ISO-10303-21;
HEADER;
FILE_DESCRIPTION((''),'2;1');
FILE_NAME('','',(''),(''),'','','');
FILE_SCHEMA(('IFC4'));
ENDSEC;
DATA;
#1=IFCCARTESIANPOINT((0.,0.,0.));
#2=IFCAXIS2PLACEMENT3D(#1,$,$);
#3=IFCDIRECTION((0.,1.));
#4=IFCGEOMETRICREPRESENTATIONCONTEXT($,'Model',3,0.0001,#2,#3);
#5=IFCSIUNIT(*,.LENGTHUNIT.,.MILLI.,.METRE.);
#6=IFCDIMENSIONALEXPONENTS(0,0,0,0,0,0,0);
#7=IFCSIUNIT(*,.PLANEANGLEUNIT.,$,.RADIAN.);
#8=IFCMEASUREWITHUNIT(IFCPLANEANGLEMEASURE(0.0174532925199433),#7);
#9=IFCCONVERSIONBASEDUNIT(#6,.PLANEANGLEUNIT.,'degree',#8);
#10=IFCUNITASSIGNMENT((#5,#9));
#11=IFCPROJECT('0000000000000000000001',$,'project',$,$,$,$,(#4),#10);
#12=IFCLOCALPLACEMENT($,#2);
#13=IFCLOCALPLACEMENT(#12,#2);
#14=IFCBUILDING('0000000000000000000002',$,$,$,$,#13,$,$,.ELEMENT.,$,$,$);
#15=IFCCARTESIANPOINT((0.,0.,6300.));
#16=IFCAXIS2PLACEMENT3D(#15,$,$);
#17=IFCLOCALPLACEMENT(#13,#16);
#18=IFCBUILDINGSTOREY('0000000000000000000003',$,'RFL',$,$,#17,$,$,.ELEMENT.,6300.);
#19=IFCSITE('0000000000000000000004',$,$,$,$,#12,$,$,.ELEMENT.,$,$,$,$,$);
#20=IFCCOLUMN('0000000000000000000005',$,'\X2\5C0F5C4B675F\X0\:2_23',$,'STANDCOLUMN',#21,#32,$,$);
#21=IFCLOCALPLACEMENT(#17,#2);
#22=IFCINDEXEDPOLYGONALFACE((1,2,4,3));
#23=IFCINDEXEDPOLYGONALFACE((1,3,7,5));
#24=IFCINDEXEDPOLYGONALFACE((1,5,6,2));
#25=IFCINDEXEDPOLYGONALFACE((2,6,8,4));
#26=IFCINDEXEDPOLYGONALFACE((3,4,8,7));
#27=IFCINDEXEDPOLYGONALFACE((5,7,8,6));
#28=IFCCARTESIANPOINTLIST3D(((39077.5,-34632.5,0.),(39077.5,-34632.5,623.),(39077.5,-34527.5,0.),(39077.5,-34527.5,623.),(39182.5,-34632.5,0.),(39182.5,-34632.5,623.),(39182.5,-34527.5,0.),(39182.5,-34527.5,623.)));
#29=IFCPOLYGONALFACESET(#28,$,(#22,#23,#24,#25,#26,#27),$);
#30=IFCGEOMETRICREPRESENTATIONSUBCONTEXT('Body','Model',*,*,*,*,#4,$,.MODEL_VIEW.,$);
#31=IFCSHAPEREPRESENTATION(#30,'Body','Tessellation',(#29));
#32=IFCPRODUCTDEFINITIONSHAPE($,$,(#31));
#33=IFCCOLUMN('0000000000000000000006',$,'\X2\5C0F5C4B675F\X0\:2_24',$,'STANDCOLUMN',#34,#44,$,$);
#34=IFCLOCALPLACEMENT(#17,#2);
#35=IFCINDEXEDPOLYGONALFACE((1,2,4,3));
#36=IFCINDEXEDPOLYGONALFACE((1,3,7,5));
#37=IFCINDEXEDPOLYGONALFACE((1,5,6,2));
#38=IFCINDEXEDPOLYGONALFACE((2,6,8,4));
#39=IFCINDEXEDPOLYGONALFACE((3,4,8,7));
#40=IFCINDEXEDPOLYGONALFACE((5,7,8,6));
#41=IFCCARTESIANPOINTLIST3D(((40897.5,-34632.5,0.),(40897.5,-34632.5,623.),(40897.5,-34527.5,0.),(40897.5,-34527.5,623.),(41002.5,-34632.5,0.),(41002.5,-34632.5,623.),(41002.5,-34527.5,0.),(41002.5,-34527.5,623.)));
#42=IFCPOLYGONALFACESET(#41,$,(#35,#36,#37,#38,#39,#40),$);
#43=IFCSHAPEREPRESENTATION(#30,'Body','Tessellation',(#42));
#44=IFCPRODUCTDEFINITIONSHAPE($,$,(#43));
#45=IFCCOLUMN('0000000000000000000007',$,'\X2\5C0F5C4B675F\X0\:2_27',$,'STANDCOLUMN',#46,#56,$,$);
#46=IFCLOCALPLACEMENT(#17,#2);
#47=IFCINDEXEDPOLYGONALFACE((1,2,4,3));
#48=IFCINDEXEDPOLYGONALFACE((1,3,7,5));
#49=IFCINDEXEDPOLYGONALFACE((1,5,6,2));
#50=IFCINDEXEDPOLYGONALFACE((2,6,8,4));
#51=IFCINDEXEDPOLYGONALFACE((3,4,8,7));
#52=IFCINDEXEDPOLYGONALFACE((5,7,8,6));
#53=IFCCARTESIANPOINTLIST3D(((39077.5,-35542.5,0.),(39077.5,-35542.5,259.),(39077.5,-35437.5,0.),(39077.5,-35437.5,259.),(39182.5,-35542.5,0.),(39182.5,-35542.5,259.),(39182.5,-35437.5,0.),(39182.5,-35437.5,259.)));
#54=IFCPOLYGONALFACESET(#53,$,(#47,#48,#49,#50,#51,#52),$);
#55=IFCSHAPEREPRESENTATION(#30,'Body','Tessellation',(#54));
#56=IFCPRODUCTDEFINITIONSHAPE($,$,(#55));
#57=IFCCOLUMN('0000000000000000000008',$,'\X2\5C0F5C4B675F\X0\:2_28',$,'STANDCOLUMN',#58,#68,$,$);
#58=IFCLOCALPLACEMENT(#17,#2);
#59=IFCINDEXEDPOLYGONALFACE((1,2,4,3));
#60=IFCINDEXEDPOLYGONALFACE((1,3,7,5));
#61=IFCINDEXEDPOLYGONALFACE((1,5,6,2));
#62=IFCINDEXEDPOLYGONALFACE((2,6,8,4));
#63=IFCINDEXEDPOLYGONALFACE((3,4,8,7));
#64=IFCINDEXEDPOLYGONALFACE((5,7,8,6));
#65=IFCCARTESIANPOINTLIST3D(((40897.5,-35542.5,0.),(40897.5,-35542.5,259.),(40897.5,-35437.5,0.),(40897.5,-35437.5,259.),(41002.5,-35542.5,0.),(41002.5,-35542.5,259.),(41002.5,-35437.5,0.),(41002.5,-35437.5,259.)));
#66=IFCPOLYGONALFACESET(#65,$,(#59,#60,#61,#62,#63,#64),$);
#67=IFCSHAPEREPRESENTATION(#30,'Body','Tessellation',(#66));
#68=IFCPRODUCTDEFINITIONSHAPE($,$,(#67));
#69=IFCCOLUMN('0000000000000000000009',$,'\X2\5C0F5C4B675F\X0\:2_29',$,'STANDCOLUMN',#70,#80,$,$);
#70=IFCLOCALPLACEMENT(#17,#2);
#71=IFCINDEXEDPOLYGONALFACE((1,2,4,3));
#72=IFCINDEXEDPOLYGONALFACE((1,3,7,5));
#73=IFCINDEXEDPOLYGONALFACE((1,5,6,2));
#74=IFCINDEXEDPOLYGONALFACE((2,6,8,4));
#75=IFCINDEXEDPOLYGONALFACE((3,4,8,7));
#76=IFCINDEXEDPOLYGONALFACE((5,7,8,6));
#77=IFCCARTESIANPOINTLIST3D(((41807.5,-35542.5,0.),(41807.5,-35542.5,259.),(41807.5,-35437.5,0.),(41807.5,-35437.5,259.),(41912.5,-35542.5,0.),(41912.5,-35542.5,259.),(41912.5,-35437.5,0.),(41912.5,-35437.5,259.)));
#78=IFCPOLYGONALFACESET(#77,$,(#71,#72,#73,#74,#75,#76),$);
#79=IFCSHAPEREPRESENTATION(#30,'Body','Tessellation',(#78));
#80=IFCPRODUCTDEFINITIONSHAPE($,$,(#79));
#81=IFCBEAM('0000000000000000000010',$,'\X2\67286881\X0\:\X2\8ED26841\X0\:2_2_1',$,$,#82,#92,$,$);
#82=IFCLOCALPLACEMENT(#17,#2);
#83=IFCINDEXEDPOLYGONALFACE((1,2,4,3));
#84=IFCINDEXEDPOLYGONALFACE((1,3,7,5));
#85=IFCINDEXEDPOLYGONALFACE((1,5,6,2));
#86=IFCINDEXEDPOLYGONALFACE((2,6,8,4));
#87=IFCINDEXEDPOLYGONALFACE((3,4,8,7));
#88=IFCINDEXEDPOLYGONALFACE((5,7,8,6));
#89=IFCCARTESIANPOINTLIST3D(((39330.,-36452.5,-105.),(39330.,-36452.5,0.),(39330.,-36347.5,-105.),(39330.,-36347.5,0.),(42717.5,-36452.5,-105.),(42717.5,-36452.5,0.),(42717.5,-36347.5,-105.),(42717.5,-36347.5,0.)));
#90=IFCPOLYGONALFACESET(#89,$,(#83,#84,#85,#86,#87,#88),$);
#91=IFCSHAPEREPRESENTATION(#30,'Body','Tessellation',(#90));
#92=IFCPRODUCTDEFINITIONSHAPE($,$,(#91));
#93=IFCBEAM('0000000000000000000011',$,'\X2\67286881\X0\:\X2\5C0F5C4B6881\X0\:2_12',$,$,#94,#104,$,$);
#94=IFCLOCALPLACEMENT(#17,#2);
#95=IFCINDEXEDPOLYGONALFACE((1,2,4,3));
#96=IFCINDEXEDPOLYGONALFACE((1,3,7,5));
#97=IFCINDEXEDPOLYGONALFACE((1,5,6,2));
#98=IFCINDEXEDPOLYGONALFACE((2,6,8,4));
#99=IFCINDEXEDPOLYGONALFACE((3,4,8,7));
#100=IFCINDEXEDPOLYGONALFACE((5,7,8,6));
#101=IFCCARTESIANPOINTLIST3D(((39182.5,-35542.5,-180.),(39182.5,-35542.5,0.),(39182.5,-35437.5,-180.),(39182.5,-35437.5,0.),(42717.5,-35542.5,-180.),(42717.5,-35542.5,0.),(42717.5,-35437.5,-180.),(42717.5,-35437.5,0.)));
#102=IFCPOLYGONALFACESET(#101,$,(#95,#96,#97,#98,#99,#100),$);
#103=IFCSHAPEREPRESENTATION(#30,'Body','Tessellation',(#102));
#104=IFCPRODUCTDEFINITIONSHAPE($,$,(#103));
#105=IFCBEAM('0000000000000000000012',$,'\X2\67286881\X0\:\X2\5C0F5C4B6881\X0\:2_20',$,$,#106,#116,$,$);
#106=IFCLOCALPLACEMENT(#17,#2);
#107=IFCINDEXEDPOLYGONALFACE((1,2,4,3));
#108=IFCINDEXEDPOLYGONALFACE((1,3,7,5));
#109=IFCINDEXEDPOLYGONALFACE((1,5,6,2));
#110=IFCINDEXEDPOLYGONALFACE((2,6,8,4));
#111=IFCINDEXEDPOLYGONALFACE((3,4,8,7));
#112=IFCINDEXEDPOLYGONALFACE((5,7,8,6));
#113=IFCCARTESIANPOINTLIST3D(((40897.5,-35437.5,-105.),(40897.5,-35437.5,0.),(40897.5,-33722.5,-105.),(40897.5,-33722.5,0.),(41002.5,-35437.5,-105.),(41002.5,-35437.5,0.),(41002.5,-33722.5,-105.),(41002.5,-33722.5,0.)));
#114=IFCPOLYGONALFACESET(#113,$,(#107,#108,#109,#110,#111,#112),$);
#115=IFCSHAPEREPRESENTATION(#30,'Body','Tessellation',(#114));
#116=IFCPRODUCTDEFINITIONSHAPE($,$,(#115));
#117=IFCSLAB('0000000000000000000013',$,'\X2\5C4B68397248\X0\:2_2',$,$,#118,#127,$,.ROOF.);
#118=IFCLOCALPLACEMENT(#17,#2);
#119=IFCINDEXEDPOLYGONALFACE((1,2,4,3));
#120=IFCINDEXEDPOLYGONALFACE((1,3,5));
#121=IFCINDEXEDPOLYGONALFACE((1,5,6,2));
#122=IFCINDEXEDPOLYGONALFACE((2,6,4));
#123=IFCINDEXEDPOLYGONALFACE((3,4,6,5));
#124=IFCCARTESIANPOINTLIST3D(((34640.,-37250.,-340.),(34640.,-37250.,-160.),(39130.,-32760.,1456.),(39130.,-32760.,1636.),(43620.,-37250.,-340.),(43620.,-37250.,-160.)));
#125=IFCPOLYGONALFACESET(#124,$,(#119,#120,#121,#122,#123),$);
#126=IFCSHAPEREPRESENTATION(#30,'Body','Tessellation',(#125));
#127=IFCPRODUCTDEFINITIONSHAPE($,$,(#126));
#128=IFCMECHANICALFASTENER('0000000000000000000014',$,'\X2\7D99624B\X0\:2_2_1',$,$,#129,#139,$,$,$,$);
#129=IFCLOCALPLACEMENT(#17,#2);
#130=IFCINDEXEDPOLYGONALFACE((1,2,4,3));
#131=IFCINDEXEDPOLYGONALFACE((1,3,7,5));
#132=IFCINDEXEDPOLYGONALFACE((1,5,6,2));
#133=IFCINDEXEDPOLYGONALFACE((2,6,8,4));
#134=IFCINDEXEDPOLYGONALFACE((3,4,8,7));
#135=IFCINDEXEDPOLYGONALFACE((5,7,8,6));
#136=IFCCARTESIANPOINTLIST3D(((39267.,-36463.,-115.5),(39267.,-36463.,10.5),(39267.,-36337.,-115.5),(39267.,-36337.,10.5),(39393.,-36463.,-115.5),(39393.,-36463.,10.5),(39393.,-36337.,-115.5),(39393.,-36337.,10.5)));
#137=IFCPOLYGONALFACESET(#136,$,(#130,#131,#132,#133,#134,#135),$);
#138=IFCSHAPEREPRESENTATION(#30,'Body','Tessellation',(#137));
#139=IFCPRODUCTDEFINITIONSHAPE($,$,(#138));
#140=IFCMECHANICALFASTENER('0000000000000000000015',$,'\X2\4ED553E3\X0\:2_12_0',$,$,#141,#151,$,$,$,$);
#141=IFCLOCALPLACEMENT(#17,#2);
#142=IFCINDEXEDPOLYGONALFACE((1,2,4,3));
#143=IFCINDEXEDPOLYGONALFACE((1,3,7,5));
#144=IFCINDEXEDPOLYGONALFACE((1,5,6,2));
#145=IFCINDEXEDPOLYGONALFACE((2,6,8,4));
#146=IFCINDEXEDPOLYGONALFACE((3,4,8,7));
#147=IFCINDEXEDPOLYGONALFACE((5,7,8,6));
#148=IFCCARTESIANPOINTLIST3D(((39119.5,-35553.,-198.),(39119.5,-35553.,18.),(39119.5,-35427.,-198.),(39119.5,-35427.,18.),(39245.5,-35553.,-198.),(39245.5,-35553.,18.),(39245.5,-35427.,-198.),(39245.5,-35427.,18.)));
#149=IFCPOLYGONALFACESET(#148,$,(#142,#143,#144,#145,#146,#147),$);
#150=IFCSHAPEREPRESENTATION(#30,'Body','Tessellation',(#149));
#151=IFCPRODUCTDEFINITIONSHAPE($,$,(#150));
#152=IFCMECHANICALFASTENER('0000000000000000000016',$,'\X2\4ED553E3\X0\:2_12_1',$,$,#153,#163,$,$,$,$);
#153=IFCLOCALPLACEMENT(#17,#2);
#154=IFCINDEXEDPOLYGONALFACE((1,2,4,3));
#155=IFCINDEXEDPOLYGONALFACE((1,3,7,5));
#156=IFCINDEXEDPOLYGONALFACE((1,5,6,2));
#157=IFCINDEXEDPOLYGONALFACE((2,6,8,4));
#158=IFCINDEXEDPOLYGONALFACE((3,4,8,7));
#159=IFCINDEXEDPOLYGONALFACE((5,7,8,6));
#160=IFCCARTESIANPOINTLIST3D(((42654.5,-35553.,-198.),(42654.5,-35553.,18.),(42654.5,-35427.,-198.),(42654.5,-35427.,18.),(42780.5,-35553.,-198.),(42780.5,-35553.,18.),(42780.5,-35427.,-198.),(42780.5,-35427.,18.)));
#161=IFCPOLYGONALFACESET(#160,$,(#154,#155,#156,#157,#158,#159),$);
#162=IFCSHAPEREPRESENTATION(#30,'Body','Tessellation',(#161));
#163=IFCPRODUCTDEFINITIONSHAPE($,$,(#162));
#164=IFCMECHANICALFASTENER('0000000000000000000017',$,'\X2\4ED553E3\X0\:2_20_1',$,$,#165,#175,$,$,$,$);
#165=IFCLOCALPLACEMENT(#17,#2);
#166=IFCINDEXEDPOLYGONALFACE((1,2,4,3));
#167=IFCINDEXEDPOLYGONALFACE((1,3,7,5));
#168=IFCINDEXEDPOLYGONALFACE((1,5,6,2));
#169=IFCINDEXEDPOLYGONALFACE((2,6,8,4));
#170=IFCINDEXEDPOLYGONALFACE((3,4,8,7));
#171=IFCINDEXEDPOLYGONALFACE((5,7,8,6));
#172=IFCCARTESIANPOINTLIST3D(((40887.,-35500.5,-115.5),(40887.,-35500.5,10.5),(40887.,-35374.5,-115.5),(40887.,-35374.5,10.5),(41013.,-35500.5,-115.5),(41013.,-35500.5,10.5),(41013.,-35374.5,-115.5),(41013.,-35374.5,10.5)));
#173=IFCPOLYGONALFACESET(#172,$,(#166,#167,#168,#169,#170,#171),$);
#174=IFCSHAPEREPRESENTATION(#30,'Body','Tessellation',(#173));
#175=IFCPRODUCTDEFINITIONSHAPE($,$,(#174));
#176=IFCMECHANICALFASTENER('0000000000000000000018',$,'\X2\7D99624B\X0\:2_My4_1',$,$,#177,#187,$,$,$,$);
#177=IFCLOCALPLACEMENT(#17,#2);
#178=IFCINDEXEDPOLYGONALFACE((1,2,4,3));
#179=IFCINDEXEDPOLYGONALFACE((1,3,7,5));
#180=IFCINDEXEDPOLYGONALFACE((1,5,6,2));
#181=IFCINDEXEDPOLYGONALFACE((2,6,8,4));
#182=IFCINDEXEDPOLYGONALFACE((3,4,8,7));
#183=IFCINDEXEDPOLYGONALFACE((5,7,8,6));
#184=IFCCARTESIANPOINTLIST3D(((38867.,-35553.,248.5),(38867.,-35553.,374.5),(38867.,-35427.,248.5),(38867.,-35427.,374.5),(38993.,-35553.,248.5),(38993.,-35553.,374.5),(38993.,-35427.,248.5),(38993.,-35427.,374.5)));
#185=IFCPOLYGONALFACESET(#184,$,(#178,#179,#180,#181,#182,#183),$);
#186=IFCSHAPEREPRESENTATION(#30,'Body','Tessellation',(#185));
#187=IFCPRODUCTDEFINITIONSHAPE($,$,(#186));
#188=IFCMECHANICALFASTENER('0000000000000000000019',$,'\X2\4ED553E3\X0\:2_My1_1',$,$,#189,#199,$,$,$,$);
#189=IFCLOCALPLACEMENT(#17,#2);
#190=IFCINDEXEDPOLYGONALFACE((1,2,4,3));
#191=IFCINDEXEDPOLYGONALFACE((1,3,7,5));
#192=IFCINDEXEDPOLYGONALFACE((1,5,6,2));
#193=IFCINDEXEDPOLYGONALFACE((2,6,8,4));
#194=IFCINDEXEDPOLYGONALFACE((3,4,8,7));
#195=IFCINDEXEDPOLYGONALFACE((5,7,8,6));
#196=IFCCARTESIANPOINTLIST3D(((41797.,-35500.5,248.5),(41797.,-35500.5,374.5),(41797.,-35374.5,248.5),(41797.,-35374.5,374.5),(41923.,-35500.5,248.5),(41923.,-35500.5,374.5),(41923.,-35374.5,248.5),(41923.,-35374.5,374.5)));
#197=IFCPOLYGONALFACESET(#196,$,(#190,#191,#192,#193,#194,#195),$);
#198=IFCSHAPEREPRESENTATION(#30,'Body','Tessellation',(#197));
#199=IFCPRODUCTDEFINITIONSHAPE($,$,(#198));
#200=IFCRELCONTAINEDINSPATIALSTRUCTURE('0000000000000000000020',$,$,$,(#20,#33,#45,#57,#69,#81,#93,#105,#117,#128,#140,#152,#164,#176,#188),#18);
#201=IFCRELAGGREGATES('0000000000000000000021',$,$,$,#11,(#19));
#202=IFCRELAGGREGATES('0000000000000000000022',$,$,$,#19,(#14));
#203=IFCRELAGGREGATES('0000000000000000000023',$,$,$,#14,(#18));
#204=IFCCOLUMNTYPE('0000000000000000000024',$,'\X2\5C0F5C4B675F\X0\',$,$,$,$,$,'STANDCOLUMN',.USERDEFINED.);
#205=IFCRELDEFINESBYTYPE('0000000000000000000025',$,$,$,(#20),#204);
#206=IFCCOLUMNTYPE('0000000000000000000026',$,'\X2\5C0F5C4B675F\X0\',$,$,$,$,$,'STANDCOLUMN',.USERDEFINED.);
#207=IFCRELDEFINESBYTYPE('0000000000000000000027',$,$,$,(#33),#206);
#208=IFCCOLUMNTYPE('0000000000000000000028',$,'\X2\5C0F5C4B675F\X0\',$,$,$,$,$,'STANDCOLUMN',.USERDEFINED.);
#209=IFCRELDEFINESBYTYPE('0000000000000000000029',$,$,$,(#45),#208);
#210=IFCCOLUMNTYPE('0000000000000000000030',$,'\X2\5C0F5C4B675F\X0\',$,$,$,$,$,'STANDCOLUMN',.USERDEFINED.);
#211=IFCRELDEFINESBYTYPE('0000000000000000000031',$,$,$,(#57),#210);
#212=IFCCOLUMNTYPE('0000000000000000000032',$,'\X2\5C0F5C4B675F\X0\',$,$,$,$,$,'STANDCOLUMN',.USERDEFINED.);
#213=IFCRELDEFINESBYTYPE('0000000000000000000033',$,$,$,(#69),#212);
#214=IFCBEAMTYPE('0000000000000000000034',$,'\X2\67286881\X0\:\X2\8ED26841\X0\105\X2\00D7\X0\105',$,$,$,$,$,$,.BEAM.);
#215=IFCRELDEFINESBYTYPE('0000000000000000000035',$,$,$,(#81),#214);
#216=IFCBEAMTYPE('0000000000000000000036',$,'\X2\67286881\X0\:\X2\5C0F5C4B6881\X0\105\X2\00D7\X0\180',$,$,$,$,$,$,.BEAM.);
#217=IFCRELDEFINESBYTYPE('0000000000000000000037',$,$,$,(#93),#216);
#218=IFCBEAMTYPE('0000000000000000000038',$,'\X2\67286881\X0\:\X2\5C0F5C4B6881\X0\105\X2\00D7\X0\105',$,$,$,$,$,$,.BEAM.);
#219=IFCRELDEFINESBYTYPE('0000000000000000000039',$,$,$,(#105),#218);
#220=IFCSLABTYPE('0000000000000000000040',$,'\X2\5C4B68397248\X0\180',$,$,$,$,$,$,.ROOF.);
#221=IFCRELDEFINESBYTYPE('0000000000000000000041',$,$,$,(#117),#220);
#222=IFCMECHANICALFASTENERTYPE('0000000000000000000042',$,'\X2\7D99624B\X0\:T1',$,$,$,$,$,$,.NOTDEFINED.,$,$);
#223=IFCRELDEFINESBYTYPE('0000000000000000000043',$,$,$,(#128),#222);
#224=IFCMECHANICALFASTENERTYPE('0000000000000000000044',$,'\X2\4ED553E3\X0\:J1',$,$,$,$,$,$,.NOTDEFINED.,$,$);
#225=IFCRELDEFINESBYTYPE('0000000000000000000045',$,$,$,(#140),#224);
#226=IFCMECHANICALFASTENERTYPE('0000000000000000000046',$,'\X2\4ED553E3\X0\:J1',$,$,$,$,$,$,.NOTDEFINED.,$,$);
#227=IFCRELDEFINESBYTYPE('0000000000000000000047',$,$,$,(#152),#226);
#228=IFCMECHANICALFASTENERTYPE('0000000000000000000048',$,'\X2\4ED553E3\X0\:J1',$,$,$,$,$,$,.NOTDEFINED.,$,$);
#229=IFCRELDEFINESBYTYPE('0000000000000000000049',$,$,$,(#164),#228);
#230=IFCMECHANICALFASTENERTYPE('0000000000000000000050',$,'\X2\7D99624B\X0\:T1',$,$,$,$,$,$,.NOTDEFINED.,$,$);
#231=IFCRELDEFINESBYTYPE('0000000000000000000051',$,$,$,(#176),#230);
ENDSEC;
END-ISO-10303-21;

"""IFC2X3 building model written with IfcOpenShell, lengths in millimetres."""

from ifc_helpers import new_model, entity, si_unit, converted_unit, direction, frame, origin, origin_with_axes, origin_2d, place, context, subcontext, project, spatial, polyline, rectangle, outline, extrude, type_object, element, save


model = new_model("IFC2X3")

# Units and contexts
model_context = context("Model", 3, precision=0.0001, world=origin(), true_north=direction((0.0, 1.0)))
body_context = subcontext(model_context, "Body", "Model", "MODEL_VIEW")
ifc_project = project(units=[si_unit("LENGTHUNIT", "METRE", prefix="MILLI"), converted_unit("PLANEANGLEUNIT", "degree", entity("IfcPlaneAngleMeasure", 0.0174532925199433), si_unit("PLANEANGLEUNIT", "RADIAN"), dimensions=[0, 0, 0, 0, 0, 0, 0])], contexts=[model_context])

# Site, building, storey
site_placement = place(None, origin())
site = spatial("IfcSite", under=ifc_project, at=site_placement, CompositionType="ELEMENT")
building_placement = place(site_placement, origin())
building = spatial("IfcBuilding", under=site, at=building_placement, CompositionType="ELEMENT")
storey_placement = place(building_placement, frame((0.0, 0.0, 6300.0)))
storey = spatial("IfcBuildingStorey", under=building, at=storey_placement, Name="RFL", CompositionType="ELEMENT", Elevation=6300.0)

# Columns
column_type_1 = type_object("IfcColumnType", Name="小屋束", ElementType="STANDCOLUMN", PredefinedType="USERDEFINED")
column_1_placement = place(storey_placement, frame((39130.0, -34580.0, 0.0)))
element("IfcColumn", 1, at=column_1_placement, inside=storey, type_object=column_type_1, Name="小屋束:2_23", ObjectType="STANDCOLUMN", context=body_context, shape_type="SweptSolid", body=[
    extrude(rectangle(XDim=105.0, YDim=105.0, at=origin_2d()), origin_with_axes(), (0.0, 0.0, 1.0), 623.0),
])
column_type_2 = type_object("IfcColumnType", Name="小屋束", ElementType="STANDCOLUMN", PredefinedType="USERDEFINED")
column_2_placement = place(storey_placement, frame((40950.0, -34580.0, 0.0)))
element("IfcColumn", 2, at=column_2_placement, inside=storey, type_object=column_type_2, Name="小屋束:2_24", ObjectType="STANDCOLUMN", context=body_context, shape_type="SweptSolid", body=[
    extrude(rectangle(XDim=105.0, YDim=105.0, at=origin_2d()), origin_with_axes(), (0.0, 0.0, 1.0), 623.0),
])
column_type_3 = type_object("IfcColumnType", Name="小屋束", ElementType="STANDCOLUMN", PredefinedType="USERDEFINED")
column_3_placement = place(storey_placement, frame((39130.0, -35490.0, 0.0)))
element("IfcColumn", 3, at=column_3_placement, inside=storey, type_object=column_type_3, Name="小屋束:2_27", ObjectType="STANDCOLUMN", context=body_context, shape_type="SweptSolid", body=[
    extrude(rectangle(XDim=105.0, YDim=105.0, at=origin_2d()), origin_with_axes(), (0.0, 0.0, 1.0), 259.0),
])
column_type_4 = type_object("IfcColumnType", Name="小屋束", ElementType="STANDCOLUMN", PredefinedType="USERDEFINED")
column_4_placement = place(storey_placement, frame((40950.0, -35490.0, 0.0)))
element("IfcColumn", 4, at=column_4_placement, inside=storey, type_object=column_type_4, Name="小屋束:2_28", ObjectType="STANDCOLUMN", context=body_context, shape_type="SweptSolid", body=[
    extrude(rectangle(XDim=105.0, YDim=105.0, at=origin_2d()), origin_with_axes(), (0.0, 0.0, 1.0), 259.0),
])
column_type_5 = type_object("IfcColumnType", Name="小屋束", ElementType="STANDCOLUMN", PredefinedType="USERDEFINED")
column_5_placement = place(storey_placement, frame((41860.0, -35490.0, 0.0)))
element("IfcColumn", 5, at=column_5_placement, inside=storey, type_object=column_type_5, Name="小屋束:2_29", ObjectType="STANDCOLUMN", context=body_context, shape_type="SweptSolid", body=[
    extrude(rectangle(XDim=105.0, YDim=105.0, at=origin_2d()), origin_with_axes(), (0.0, 0.0, 1.0), 259.0),
])

# Beams
beam_type_1 = type_object("IfcBeamType", Name="木梁:軒桁105×105", PredefinedType="BEAM")
beam_1_placement = place(storey_placement, frame((39330.0, -36400.0, -52.5), z_axis=(1.0, 0.0, 0.0), x_axis=(0.0, 1.0, 0.0)))
element("IfcBeam", 6, at=beam_1_placement, inside=storey, type_object=beam_type_1, Name="木梁:軒桁:2_2_1", context=body_context, shape_type="SweptSolid", body=[
    extrude(rectangle(XDim=105.0, YDim=105.0, at=origin_2d()), origin_with_axes(), (0.0, 0.0, 1.0), 3387.5),
])
beam_type_2 = type_object("IfcBeamType", Name="木梁:小屋梁105×180", PredefinedType="BEAM")
beam_2_placement = place(storey_placement, frame((39182.5, -35490.0, -90.0), z_axis=(1.0, 0.0, 0.0), x_axis=(0.0, 1.0, 0.0)))
element("IfcBeam", 7, at=beam_2_placement, inside=storey, type_object=beam_type_2, Name="木梁:小屋梁:2_12", context=body_context, shape_type="SweptSolid", body=[
    extrude(rectangle(XDim=105.0, YDim=180.0, at=origin_2d()), origin_with_axes(), (0.0, 0.0, 1.0), 3535.0),
])
beam_type_3 = type_object("IfcBeamType", Name="木梁:小屋梁105×105", PredefinedType="BEAM")
beam_3_placement = place(storey_placement, frame((40950.0, -33722.5, -52.5), z_axis=(0.0, -1.0, 0.0), x_axis=(1.0, 0.0, 0.0)))
element("IfcBeam", 8, at=beam_3_placement, inside=storey, type_object=beam_type_3, Name="木梁:小屋梁:2_20", context=body_context, shape_type="SweptSolid", body=[
    extrude(rectangle(XDim=105.0, YDim=105.0, at=origin_2d()), origin_with_axes(), (0.0, 0.0, 1.0), 1715.0),
])

# Slab
slab_type = type_object("IfcSlabType", Name="屋根版180", PredefinedType="ROOF")
slab_placement = place(storey_placement, frame((43620.0, -37250.0, -340.0), z_axis=(0.0, 0.371391, -0.928477), x_axis=(-1.0, 0.0, 0.0)))
element("IfcSlab", 9, at=slab_placement, inside=storey, type_object=slab_type, Name="屋根版:2_2", PredefinedType="ROOF", context=body_context, shape_type="SweptSolid", body=[
    extrude(outline(polyline([(0.0, 0.0, 0.0), (8980.0, 0.0, 0.0), (4490.0, 4835.9, 0.0), (0.0, 0.0, 0.0)])), origin_with_axes(), (0.0, 0.371391, -0.928477), 180.0),
])

# Mechanical fasteners
mechanical_fastener_type_1 = type_object("IfcMechanicalFastenerType", Name="継手:T1")
mechanical_fastener_1_placement = place(storey_placement, frame((39330.0, -36400.0, -115.5)))
element("IfcMechanicalFastener", 10, at=mechanical_fastener_1_placement, inside=storey, type_object=mechanical_fastener_type_1, Name="継手:2_2_1", context=body_context, shape_type="SweptSolid", body=[
    extrude(rectangle(XDim=126.0, YDim=126.0, at=origin_2d()), origin_with_axes(), (0.0, 0.0, 1.0), 126.0),
])
mechanical_fastener_type_2 = type_object("IfcMechanicalFastenerType", Name="仕口:J1")
mechanical_fastener_2_placement = place(storey_placement, frame((39182.5, -35490.0, -198.0)))
element("IfcMechanicalFastener", 11, at=mechanical_fastener_2_placement, inside=storey, type_object=mechanical_fastener_type_2, Name="仕口:2_12_0", context=body_context, shape_type="SweptSolid", body=[
    extrude(rectangle(XDim=126.0, YDim=126.0, at=origin_2d()), origin_with_axes(), (0.0, 0.0, 1.0), 216.0),
])
mechanical_fastener_type_3 = type_object("IfcMechanicalFastenerType", Name="仕口:J1")
mechanical_fastener_3_placement = place(storey_placement, frame((42717.5, -35490.0, -198.0)))
element("IfcMechanicalFastener", 12, at=mechanical_fastener_3_placement, inside=storey, type_object=mechanical_fastener_type_3, Name="仕口:2_12_1", context=body_context, shape_type="SweptSolid", body=[
    extrude(rectangle(XDim=126.0, YDim=126.0, at=origin_2d()), origin_with_axes(), (0.0, 0.0, 1.0), 216.0),
])
mechanical_fastener_type_4 = type_object("IfcMechanicalFastenerType", Name="仕口:J1")
mechanical_fastener_4_placement = place(storey_placement, frame((40950.0, -35437.5, -115.5)))
element("IfcMechanicalFastener", 13, at=mechanical_fastener_4_placement, inside=storey, type_object=mechanical_fastener_type_4, Name="仕口:2_20_1", context=body_context, shape_type="SweptSolid", body=[
    extrude(rectangle(XDim=126.0, YDim=126.0, at=origin_2d()), origin_with_axes(), (0.0, 0.0, 1.0), 126.0),
])
mechanical_fastener_type_5 = type_object("IfcMechanicalFastenerType", Name="継手:T1")
mechanical_fastener_5_placement = place(storey_placement, frame((38930.0, -35490.0, 248.5)))
element("IfcMechanicalFastener", 14, at=mechanical_fastener_5_placement, inside=storey, type_object=mechanical_fastener_type_5, Name="継手:2_My4_1", context=body_context, shape_type="SweptSolid", body=[
    extrude(rectangle(XDim=126.0, YDim=126.0, at=origin_2d()), origin_with_axes(), (0.0, 0.0, 1.0), 126.0),
])
for number, where, name in (
    (15, (41860.0, -35437.5, 248.5), "仕口:2_My1_1"),
):
    element("IfcMechanicalFastener", number, at=place(storey_placement, frame(where)), inside=storey, Name=name, context=body_context, shape_type="SweptSolid", body=[
        extrude(rectangle(XDim=126.0, YDim=126.0, at=origin_2d()), origin_with_axes(), (0.0, 0.0, 1.0), 126.0),
    ])

save(model, "model.ifc")
